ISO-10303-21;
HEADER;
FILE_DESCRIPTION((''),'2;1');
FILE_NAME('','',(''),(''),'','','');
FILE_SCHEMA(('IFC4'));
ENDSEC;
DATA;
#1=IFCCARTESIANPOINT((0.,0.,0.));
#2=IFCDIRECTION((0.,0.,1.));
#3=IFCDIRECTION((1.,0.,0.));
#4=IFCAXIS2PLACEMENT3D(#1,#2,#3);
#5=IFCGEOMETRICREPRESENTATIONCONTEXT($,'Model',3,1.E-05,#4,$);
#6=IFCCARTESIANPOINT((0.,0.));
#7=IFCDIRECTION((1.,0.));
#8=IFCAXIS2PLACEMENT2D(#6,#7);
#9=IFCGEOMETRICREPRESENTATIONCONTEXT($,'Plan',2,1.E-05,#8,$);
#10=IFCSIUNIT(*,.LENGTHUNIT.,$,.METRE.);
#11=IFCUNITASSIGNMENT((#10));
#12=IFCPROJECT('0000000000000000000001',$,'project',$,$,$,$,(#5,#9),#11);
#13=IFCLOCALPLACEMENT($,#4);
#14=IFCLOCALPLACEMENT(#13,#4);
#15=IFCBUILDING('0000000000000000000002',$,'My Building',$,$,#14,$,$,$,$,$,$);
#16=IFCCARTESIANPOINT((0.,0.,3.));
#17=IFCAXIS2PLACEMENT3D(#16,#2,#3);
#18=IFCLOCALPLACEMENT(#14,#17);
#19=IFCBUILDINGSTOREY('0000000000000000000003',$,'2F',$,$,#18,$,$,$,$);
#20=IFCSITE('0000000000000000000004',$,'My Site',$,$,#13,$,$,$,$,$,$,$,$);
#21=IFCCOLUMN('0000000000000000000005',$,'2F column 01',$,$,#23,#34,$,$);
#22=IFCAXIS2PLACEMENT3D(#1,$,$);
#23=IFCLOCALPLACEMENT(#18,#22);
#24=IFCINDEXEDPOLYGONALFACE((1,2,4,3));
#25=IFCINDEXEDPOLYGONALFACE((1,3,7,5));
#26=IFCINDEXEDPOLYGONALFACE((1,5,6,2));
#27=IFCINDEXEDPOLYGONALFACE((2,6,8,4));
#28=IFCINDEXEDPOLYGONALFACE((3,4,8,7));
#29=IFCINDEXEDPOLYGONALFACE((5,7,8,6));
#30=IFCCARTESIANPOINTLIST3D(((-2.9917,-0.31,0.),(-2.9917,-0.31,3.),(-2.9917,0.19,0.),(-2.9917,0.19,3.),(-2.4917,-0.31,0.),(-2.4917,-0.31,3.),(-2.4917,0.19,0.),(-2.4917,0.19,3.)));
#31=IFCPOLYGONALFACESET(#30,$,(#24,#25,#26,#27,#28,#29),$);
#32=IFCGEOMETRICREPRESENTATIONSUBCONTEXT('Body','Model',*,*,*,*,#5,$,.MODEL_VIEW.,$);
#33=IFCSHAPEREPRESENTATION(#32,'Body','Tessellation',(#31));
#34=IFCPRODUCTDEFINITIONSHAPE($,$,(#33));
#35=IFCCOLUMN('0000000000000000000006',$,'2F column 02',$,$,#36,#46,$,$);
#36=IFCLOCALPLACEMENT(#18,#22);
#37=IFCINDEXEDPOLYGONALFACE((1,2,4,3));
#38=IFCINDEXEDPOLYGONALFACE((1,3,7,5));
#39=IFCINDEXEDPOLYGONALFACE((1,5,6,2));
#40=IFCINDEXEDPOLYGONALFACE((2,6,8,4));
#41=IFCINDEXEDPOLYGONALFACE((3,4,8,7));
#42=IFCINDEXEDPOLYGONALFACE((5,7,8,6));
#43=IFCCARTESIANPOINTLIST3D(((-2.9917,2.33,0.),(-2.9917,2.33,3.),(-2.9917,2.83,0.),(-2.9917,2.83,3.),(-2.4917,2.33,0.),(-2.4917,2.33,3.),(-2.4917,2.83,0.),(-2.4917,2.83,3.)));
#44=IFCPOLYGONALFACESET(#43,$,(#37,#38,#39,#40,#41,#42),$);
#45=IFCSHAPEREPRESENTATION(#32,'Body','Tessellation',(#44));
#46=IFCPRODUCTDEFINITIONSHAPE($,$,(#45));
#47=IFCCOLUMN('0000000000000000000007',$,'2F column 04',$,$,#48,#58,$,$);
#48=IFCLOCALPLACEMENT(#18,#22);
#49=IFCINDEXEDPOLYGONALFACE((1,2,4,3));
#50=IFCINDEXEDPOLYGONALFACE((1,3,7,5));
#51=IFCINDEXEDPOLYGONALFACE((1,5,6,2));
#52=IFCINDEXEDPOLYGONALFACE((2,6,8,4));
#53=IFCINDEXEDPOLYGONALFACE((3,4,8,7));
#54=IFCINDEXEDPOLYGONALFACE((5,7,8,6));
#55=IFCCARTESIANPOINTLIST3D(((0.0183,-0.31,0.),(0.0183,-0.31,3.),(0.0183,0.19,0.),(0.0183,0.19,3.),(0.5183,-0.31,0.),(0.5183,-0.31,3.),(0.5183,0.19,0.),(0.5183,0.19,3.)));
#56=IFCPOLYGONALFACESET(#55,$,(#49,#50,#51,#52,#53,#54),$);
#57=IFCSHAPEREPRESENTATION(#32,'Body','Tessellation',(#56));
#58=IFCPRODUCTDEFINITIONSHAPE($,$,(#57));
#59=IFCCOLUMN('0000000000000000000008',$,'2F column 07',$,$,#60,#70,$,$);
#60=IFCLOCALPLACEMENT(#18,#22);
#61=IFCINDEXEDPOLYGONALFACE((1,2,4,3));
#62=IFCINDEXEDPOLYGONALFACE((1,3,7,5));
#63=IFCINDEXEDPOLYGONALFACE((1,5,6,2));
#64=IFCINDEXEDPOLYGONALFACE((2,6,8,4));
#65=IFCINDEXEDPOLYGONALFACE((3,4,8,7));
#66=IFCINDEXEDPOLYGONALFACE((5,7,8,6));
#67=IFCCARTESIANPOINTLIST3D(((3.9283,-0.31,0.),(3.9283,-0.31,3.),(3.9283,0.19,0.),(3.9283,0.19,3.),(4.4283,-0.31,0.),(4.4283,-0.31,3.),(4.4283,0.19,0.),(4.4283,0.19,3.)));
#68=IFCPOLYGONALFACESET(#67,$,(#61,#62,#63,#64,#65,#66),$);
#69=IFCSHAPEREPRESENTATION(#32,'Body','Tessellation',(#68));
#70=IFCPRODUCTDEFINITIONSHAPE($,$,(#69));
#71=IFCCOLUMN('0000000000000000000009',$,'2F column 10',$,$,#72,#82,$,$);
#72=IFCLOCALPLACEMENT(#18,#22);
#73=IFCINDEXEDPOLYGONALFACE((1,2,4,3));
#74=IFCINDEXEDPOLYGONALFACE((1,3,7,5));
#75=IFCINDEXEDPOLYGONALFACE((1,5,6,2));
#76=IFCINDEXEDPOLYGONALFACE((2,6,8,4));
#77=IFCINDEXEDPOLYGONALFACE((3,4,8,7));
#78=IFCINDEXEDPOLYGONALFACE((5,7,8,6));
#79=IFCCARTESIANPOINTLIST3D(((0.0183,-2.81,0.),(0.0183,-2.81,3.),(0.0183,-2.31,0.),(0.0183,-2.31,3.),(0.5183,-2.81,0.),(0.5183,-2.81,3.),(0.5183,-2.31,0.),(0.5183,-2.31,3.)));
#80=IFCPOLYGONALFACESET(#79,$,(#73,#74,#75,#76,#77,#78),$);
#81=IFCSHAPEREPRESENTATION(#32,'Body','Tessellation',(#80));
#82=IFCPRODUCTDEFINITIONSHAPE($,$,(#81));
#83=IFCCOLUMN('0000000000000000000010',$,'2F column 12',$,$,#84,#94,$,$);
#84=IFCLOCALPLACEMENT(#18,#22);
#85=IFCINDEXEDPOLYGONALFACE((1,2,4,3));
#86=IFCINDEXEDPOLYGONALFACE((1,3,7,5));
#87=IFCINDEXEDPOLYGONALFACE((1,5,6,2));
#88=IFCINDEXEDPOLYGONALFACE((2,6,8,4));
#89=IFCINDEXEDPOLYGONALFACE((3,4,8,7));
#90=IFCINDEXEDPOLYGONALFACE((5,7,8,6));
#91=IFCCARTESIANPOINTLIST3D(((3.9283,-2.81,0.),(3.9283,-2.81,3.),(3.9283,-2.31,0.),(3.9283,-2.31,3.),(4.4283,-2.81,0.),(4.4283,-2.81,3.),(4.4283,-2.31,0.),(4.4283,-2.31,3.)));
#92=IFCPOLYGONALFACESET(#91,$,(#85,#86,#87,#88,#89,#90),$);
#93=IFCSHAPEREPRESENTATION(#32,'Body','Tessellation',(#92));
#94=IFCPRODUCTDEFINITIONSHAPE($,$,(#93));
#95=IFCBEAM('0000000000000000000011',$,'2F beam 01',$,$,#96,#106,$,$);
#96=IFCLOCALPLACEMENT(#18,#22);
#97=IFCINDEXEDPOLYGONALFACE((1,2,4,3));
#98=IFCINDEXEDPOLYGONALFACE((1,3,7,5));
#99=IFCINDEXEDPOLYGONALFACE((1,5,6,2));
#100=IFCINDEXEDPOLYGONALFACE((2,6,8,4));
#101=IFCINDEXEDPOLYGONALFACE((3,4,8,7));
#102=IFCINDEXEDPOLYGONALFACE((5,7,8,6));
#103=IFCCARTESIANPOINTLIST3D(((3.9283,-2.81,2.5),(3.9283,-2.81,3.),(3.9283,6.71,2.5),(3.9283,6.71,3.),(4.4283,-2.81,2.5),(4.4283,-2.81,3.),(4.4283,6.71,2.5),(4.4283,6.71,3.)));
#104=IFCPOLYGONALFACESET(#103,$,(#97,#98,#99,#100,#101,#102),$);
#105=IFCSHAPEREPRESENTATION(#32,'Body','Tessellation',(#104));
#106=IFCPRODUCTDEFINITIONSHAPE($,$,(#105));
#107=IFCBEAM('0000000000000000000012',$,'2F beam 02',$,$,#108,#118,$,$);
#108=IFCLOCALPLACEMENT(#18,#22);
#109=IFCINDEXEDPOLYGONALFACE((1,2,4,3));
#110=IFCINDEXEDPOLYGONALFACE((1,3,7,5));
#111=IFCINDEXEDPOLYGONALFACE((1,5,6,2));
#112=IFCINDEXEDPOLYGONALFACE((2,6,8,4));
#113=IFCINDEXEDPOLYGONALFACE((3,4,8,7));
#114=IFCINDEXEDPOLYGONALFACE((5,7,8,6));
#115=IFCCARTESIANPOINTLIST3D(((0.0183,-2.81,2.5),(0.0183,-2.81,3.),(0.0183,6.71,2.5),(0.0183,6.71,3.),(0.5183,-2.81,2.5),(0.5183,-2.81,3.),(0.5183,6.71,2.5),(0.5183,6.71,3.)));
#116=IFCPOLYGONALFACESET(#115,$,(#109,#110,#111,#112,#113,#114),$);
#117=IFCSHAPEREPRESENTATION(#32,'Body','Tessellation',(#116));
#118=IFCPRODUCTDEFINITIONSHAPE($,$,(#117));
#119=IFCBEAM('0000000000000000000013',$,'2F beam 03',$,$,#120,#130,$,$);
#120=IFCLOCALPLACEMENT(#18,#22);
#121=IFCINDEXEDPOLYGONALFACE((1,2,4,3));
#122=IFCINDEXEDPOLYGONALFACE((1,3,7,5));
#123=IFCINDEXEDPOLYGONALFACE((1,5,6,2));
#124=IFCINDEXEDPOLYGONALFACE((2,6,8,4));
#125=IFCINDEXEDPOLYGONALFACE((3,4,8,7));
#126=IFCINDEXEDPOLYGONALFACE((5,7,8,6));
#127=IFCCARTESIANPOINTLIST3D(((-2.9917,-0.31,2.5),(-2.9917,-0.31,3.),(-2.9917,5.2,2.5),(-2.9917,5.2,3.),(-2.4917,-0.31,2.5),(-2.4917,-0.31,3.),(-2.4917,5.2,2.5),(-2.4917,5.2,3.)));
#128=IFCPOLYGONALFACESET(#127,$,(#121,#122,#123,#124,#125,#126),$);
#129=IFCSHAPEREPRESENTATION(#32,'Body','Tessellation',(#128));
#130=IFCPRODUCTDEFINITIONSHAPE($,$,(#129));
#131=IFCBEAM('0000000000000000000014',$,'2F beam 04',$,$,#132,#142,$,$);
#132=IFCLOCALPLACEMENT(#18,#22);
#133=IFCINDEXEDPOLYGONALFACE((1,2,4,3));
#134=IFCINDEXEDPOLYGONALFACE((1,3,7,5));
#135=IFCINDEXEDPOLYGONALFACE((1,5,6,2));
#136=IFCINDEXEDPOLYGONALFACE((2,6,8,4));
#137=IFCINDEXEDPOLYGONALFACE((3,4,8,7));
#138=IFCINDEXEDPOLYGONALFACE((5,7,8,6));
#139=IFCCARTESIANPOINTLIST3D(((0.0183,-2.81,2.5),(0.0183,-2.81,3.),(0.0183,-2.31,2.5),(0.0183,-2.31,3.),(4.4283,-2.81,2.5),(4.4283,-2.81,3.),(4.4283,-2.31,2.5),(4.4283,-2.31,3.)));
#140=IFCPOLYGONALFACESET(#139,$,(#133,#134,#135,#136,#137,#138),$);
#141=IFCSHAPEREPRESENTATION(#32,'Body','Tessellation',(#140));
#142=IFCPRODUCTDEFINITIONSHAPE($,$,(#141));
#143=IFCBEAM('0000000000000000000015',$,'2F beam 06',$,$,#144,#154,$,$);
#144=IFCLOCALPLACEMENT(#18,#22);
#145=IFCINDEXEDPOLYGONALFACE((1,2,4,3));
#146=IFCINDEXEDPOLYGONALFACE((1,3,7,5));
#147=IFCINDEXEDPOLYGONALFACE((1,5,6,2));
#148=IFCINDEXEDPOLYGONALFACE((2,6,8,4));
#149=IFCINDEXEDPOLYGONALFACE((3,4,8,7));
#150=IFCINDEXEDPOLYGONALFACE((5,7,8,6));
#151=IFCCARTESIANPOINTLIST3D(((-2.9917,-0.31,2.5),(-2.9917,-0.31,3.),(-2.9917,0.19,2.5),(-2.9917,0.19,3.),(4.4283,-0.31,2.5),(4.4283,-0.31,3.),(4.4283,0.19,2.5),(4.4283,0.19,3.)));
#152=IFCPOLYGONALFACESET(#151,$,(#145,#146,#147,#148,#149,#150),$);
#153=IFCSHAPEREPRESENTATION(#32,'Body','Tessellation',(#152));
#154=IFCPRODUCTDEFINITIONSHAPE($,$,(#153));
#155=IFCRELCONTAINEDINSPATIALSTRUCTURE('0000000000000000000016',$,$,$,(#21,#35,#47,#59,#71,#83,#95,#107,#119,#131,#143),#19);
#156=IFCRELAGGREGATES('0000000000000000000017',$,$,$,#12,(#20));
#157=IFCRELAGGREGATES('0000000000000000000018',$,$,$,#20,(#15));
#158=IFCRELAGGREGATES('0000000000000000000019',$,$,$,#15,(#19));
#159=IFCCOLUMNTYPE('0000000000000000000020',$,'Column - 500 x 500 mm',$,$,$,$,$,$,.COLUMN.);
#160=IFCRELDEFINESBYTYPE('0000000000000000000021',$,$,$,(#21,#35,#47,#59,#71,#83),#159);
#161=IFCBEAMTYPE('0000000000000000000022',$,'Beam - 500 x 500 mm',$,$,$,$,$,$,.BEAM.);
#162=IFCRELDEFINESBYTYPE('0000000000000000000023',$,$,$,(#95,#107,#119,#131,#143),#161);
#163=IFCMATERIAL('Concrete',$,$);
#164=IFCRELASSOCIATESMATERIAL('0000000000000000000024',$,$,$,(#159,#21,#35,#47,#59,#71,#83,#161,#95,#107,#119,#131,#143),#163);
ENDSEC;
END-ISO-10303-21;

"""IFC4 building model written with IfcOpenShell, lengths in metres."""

from ifc_helpers import new_model, si_unit, frame, origin_with_axes, origin_2d_with_axis, place, context, subcontext, project, spatial, rectangle, extrude, material, material_profile, profile_set, profile_usage, type_object, element, save


model = new_model("IFC4")

# Units and contexts
model_context_1 = context("Model", 3, precision=1e-05, world=origin_with_axes())
plan_context = context("Plan", 2, precision=1e-05, world=origin_2d_with_axis())
body_context_1 = subcontext(model_context_1, "Body", "Model", "MODEL_VIEW")
ifc_project = project(units=[si_unit("LENGTHUNIT", "METRE")], contexts=[model_context_1, plan_context])

# Site, building, storey
site_placement = place(None, origin_with_axes())
site = spatial("IfcSite", under=ifc_project, at=site_placement, Name="My Site")
building_placement = place(site_placement, origin_with_axes())
building = spatial("IfcBuilding", under=site, at=building_placement, Name="My Building")
storey_placement = place(building_placement, frame((0.0, 0.0, 3.0), z_axis=(0.0, 0.0, 1.0), x_axis=(1.0, 0.0, 0.0)))
storey = spatial("IfcBuildingStorey", under=building, at=storey_placement, Name="2F")

# Columns
ifc_material_1 = material(Name="Concrete")
ifc_material_profile_1 = material_profile(ifc_material_1, rectangle(XDim=0.5, YDim=0.5))
ifc_profile_set_1 = profile_set([ifc_material_profile_1])
ifc_profile_usage_1 = profile_usage(ifc_profile_set_1, cardinal=5)
column_type = type_object("IfcColumnType", Name="Column - 500 x 500 mm", PredefinedType="COLUMN", material=ifc_profile_set_1)
column_1_placement = place(storey_placement, frame((-2.7417, -0.06, 0.0), z_axis=(0.0, 0.0, 1.0), x_axis=(1.0, 0.0, 0.0)))
element("IfcColumn", 1, at=column_1_placement, inside=storey, type_object=column_type, material=ifc_profile_usage_1, Name="2F column 01", context=body_context_1, shape_type="SweptSolid", body=[
    extrude(rectangle(XDim=0.5, YDim=0.5), origin_with_axes(), (0.0, 0.0, 1.0), 3.0),
])
ifc_profile_usage_2 = profile_usage(ifc_profile_set_1, cardinal=5)
column_2_placement = place(storey_placement, frame((-2.7417, 2.58, 0.0), z_axis=(0.0, 0.0, 1.0), x_axis=(1.0, 0.0, 0.0)))
element("IfcColumn", 2, at=column_2_placement, inside=storey, type_object=column_type, material=ifc_profile_usage_2, Name="2F column 02", context=body_context_1, shape_type="SweptSolid", body=[
    extrude(rectangle(XDim=0.5, YDim=0.5), origin_with_axes(), (0.0, 0.0, 1.0), 3.0),
])
ifc_profile_usage_3 = profile_usage(ifc_profile_set_1, cardinal=5)
column_3_placement = place(storey_placement, frame((0.2683, -0.06, 0.0), z_axis=(0.0, 0.0, 1.0), x_axis=(1.0, 0.0, 0.0)))
element("IfcColumn", 3, at=column_3_placement, inside=storey, type_object=column_type, material=ifc_profile_usage_3, Name="2F column 04", context=body_context_1, shape_type="SweptSolid", body=[
    extrude(rectangle(XDim=0.5, YDim=0.5), origin_with_axes(), (0.0, 0.0, 1.0), 3.0),
])
ifc_profile_usage_4 = profile_usage(ifc_profile_set_1, cardinal=5)
column_4_placement = place(storey_placement, frame((4.1783, -0.06, 0.0), z_axis=(0.0, 0.0, 1.0), x_axis=(1.0, 0.0, 0.0)))
element("IfcColumn", 4, at=column_4_placement, inside=storey, type_object=column_type, material=ifc_profile_usage_4, Name="2F column 07", context=body_context_1, shape_type="SweptSolid", body=[
    extrude(rectangle(XDim=0.5, YDim=0.5), origin_with_axes(), (0.0, 0.0, 1.0), 3.0),
])
ifc_profile_usage_5 = profile_usage(ifc_profile_set_1, cardinal=5)
column_5_placement = place(storey_placement, frame((0.2683, -2.56, 0.0), z_axis=(0.0, 0.0, 1.0), x_axis=(1.0, 0.0, 0.0)))
element("IfcColumn", 5, at=column_5_placement, inside=storey, type_object=column_type, material=ifc_profile_usage_5, Name="2F column 10", context=body_context_1, shape_type="SweptSolid", body=[
    extrude(rectangle(XDim=0.5, YDim=0.5), origin_with_axes(), (0.0, 0.0, 1.0), 3.0),
])
ifc_profile_usage_6 = profile_usage(ifc_profile_set_1, cardinal=5)
column_6_placement = place(storey_placement, frame((4.1783, -2.56, 0.0), z_axis=(0.0, 0.0, 1.0), x_axis=(1.0, 0.0, 0.0)))
element("IfcColumn", 6, at=column_6_placement, inside=storey, type_object=column_type, material=ifc_profile_usage_6, Name="2F column 12", context=body_context_1, shape_type="SweptSolid", body=[
    extrude(rectangle(XDim=0.5, YDim=0.5), origin_with_axes(), (0.0, 0.0, 1.0), 3.0),
])

# Beams
ifc_material_profile_2 = material_profile(ifc_material_1, rectangle(XDim=0.5, YDim=0.5))
ifc_profile_set_2 = profile_set([ifc_material_profile_2])
ifc_profile_usage_7 = profile_usage(ifc_profile_set_2, cardinal=5)
beam_type = type_object("IfcBeamType", Name="Beam - 500 x 500 mm", PredefinedType="BEAM", material=ifc_profile_set_2)
beam_1_placement = place(storey_placement, frame((4.1783, -2.81, 2.75), z_axis=(0.0, 1.0, 0.0), x_axis=(0.0, 0.0, 1.0)))
element("IfcBeam", 7, at=beam_1_placement, inside=storey, type_object=beam_type, material=ifc_profile_usage_7, Name="2F beam 01", context=body_context_1, shape_type="SweptSolid", body=[
    extrude(rectangle(XDim=0.5, YDim=0.5), origin_with_axes(), (0.0, 0.0, 1.0), 9.52),
])
ifc_profile_usage_8 = profile_usage(ifc_profile_set_2, cardinal=5)
beam_2_placement = place(storey_placement, frame((0.2683, -2.81, 2.75), z_axis=(0.0, 1.0, 0.0), x_axis=(0.0, 0.0, 1.0)))
element("IfcBeam", 8, at=beam_2_placement, inside=storey, type_object=beam_type, material=ifc_profile_usage_8, Name="2F beam 02", context=body_context_1, shape_type="SweptSolid", body=[
    extrude(rectangle(XDim=0.5, YDim=0.5), origin_with_axes(), (0.0, 0.0, 1.0), 9.52),
])
ifc_profile_usage_9 = profile_usage(ifc_profile_set_2, cardinal=5)
beam_3_placement = place(storey_placement, frame((-2.7417, -0.31, 2.75), z_axis=(0.0, 1.0, 0.0), x_axis=(0.0, 0.0, 1.0)))
element("IfcBeam", 9, at=beam_3_placement, inside=storey, type_object=beam_type, material=ifc_profile_usage_9, Name="2F beam 03", context=body_context_1, shape_type="SweptSolid", body=[
    extrude(rectangle(XDim=0.5, YDim=0.5), origin_with_axes(), (0.0, 0.0, 1.0), 5.51),
])
ifc_profile_usage_10 = profile_usage(ifc_profile_set_2, cardinal=5)
beam_4_placement = place(storey_placement, frame((0.0183, -2.56, 2.75), z_axis=(1.0, 0.0, 0.0), x_axis=(0.0, 0.0, 1.0)))
element("IfcBeam", 10, at=beam_4_placement, inside=storey, type_object=beam_type, material=ifc_profile_usage_10, Name="2F beam 04", context=body_context_1, shape_type="SweptSolid", body=[
    extrude(rectangle(XDim=0.5, YDim=0.5), origin_with_axes(), (0.0, 0.0, 1.0), 4.41),
])
ifc_profile_usage_11 = profile_usage(ifc_profile_set_2, cardinal=5)
beam_5_placement = place(storey_placement, frame((-2.9917, -0.06, 2.75), z_axis=(1.0, 0.0, 0.0), x_axis=(0.0, 0.0, 1.0)))
element("IfcBeam", 11, at=beam_5_placement, inside=storey, type_object=beam_type, material=ifc_profile_usage_11, Name="2F beam 06", context=body_context_1, shape_type="SweptSolid", body=[
    extrude(rectangle(XDim=0.5, YDim=0.5), origin_with_axes(), (0.0, 0.0, 1.0), 7.42),
])

save(model, "model.ifc")
